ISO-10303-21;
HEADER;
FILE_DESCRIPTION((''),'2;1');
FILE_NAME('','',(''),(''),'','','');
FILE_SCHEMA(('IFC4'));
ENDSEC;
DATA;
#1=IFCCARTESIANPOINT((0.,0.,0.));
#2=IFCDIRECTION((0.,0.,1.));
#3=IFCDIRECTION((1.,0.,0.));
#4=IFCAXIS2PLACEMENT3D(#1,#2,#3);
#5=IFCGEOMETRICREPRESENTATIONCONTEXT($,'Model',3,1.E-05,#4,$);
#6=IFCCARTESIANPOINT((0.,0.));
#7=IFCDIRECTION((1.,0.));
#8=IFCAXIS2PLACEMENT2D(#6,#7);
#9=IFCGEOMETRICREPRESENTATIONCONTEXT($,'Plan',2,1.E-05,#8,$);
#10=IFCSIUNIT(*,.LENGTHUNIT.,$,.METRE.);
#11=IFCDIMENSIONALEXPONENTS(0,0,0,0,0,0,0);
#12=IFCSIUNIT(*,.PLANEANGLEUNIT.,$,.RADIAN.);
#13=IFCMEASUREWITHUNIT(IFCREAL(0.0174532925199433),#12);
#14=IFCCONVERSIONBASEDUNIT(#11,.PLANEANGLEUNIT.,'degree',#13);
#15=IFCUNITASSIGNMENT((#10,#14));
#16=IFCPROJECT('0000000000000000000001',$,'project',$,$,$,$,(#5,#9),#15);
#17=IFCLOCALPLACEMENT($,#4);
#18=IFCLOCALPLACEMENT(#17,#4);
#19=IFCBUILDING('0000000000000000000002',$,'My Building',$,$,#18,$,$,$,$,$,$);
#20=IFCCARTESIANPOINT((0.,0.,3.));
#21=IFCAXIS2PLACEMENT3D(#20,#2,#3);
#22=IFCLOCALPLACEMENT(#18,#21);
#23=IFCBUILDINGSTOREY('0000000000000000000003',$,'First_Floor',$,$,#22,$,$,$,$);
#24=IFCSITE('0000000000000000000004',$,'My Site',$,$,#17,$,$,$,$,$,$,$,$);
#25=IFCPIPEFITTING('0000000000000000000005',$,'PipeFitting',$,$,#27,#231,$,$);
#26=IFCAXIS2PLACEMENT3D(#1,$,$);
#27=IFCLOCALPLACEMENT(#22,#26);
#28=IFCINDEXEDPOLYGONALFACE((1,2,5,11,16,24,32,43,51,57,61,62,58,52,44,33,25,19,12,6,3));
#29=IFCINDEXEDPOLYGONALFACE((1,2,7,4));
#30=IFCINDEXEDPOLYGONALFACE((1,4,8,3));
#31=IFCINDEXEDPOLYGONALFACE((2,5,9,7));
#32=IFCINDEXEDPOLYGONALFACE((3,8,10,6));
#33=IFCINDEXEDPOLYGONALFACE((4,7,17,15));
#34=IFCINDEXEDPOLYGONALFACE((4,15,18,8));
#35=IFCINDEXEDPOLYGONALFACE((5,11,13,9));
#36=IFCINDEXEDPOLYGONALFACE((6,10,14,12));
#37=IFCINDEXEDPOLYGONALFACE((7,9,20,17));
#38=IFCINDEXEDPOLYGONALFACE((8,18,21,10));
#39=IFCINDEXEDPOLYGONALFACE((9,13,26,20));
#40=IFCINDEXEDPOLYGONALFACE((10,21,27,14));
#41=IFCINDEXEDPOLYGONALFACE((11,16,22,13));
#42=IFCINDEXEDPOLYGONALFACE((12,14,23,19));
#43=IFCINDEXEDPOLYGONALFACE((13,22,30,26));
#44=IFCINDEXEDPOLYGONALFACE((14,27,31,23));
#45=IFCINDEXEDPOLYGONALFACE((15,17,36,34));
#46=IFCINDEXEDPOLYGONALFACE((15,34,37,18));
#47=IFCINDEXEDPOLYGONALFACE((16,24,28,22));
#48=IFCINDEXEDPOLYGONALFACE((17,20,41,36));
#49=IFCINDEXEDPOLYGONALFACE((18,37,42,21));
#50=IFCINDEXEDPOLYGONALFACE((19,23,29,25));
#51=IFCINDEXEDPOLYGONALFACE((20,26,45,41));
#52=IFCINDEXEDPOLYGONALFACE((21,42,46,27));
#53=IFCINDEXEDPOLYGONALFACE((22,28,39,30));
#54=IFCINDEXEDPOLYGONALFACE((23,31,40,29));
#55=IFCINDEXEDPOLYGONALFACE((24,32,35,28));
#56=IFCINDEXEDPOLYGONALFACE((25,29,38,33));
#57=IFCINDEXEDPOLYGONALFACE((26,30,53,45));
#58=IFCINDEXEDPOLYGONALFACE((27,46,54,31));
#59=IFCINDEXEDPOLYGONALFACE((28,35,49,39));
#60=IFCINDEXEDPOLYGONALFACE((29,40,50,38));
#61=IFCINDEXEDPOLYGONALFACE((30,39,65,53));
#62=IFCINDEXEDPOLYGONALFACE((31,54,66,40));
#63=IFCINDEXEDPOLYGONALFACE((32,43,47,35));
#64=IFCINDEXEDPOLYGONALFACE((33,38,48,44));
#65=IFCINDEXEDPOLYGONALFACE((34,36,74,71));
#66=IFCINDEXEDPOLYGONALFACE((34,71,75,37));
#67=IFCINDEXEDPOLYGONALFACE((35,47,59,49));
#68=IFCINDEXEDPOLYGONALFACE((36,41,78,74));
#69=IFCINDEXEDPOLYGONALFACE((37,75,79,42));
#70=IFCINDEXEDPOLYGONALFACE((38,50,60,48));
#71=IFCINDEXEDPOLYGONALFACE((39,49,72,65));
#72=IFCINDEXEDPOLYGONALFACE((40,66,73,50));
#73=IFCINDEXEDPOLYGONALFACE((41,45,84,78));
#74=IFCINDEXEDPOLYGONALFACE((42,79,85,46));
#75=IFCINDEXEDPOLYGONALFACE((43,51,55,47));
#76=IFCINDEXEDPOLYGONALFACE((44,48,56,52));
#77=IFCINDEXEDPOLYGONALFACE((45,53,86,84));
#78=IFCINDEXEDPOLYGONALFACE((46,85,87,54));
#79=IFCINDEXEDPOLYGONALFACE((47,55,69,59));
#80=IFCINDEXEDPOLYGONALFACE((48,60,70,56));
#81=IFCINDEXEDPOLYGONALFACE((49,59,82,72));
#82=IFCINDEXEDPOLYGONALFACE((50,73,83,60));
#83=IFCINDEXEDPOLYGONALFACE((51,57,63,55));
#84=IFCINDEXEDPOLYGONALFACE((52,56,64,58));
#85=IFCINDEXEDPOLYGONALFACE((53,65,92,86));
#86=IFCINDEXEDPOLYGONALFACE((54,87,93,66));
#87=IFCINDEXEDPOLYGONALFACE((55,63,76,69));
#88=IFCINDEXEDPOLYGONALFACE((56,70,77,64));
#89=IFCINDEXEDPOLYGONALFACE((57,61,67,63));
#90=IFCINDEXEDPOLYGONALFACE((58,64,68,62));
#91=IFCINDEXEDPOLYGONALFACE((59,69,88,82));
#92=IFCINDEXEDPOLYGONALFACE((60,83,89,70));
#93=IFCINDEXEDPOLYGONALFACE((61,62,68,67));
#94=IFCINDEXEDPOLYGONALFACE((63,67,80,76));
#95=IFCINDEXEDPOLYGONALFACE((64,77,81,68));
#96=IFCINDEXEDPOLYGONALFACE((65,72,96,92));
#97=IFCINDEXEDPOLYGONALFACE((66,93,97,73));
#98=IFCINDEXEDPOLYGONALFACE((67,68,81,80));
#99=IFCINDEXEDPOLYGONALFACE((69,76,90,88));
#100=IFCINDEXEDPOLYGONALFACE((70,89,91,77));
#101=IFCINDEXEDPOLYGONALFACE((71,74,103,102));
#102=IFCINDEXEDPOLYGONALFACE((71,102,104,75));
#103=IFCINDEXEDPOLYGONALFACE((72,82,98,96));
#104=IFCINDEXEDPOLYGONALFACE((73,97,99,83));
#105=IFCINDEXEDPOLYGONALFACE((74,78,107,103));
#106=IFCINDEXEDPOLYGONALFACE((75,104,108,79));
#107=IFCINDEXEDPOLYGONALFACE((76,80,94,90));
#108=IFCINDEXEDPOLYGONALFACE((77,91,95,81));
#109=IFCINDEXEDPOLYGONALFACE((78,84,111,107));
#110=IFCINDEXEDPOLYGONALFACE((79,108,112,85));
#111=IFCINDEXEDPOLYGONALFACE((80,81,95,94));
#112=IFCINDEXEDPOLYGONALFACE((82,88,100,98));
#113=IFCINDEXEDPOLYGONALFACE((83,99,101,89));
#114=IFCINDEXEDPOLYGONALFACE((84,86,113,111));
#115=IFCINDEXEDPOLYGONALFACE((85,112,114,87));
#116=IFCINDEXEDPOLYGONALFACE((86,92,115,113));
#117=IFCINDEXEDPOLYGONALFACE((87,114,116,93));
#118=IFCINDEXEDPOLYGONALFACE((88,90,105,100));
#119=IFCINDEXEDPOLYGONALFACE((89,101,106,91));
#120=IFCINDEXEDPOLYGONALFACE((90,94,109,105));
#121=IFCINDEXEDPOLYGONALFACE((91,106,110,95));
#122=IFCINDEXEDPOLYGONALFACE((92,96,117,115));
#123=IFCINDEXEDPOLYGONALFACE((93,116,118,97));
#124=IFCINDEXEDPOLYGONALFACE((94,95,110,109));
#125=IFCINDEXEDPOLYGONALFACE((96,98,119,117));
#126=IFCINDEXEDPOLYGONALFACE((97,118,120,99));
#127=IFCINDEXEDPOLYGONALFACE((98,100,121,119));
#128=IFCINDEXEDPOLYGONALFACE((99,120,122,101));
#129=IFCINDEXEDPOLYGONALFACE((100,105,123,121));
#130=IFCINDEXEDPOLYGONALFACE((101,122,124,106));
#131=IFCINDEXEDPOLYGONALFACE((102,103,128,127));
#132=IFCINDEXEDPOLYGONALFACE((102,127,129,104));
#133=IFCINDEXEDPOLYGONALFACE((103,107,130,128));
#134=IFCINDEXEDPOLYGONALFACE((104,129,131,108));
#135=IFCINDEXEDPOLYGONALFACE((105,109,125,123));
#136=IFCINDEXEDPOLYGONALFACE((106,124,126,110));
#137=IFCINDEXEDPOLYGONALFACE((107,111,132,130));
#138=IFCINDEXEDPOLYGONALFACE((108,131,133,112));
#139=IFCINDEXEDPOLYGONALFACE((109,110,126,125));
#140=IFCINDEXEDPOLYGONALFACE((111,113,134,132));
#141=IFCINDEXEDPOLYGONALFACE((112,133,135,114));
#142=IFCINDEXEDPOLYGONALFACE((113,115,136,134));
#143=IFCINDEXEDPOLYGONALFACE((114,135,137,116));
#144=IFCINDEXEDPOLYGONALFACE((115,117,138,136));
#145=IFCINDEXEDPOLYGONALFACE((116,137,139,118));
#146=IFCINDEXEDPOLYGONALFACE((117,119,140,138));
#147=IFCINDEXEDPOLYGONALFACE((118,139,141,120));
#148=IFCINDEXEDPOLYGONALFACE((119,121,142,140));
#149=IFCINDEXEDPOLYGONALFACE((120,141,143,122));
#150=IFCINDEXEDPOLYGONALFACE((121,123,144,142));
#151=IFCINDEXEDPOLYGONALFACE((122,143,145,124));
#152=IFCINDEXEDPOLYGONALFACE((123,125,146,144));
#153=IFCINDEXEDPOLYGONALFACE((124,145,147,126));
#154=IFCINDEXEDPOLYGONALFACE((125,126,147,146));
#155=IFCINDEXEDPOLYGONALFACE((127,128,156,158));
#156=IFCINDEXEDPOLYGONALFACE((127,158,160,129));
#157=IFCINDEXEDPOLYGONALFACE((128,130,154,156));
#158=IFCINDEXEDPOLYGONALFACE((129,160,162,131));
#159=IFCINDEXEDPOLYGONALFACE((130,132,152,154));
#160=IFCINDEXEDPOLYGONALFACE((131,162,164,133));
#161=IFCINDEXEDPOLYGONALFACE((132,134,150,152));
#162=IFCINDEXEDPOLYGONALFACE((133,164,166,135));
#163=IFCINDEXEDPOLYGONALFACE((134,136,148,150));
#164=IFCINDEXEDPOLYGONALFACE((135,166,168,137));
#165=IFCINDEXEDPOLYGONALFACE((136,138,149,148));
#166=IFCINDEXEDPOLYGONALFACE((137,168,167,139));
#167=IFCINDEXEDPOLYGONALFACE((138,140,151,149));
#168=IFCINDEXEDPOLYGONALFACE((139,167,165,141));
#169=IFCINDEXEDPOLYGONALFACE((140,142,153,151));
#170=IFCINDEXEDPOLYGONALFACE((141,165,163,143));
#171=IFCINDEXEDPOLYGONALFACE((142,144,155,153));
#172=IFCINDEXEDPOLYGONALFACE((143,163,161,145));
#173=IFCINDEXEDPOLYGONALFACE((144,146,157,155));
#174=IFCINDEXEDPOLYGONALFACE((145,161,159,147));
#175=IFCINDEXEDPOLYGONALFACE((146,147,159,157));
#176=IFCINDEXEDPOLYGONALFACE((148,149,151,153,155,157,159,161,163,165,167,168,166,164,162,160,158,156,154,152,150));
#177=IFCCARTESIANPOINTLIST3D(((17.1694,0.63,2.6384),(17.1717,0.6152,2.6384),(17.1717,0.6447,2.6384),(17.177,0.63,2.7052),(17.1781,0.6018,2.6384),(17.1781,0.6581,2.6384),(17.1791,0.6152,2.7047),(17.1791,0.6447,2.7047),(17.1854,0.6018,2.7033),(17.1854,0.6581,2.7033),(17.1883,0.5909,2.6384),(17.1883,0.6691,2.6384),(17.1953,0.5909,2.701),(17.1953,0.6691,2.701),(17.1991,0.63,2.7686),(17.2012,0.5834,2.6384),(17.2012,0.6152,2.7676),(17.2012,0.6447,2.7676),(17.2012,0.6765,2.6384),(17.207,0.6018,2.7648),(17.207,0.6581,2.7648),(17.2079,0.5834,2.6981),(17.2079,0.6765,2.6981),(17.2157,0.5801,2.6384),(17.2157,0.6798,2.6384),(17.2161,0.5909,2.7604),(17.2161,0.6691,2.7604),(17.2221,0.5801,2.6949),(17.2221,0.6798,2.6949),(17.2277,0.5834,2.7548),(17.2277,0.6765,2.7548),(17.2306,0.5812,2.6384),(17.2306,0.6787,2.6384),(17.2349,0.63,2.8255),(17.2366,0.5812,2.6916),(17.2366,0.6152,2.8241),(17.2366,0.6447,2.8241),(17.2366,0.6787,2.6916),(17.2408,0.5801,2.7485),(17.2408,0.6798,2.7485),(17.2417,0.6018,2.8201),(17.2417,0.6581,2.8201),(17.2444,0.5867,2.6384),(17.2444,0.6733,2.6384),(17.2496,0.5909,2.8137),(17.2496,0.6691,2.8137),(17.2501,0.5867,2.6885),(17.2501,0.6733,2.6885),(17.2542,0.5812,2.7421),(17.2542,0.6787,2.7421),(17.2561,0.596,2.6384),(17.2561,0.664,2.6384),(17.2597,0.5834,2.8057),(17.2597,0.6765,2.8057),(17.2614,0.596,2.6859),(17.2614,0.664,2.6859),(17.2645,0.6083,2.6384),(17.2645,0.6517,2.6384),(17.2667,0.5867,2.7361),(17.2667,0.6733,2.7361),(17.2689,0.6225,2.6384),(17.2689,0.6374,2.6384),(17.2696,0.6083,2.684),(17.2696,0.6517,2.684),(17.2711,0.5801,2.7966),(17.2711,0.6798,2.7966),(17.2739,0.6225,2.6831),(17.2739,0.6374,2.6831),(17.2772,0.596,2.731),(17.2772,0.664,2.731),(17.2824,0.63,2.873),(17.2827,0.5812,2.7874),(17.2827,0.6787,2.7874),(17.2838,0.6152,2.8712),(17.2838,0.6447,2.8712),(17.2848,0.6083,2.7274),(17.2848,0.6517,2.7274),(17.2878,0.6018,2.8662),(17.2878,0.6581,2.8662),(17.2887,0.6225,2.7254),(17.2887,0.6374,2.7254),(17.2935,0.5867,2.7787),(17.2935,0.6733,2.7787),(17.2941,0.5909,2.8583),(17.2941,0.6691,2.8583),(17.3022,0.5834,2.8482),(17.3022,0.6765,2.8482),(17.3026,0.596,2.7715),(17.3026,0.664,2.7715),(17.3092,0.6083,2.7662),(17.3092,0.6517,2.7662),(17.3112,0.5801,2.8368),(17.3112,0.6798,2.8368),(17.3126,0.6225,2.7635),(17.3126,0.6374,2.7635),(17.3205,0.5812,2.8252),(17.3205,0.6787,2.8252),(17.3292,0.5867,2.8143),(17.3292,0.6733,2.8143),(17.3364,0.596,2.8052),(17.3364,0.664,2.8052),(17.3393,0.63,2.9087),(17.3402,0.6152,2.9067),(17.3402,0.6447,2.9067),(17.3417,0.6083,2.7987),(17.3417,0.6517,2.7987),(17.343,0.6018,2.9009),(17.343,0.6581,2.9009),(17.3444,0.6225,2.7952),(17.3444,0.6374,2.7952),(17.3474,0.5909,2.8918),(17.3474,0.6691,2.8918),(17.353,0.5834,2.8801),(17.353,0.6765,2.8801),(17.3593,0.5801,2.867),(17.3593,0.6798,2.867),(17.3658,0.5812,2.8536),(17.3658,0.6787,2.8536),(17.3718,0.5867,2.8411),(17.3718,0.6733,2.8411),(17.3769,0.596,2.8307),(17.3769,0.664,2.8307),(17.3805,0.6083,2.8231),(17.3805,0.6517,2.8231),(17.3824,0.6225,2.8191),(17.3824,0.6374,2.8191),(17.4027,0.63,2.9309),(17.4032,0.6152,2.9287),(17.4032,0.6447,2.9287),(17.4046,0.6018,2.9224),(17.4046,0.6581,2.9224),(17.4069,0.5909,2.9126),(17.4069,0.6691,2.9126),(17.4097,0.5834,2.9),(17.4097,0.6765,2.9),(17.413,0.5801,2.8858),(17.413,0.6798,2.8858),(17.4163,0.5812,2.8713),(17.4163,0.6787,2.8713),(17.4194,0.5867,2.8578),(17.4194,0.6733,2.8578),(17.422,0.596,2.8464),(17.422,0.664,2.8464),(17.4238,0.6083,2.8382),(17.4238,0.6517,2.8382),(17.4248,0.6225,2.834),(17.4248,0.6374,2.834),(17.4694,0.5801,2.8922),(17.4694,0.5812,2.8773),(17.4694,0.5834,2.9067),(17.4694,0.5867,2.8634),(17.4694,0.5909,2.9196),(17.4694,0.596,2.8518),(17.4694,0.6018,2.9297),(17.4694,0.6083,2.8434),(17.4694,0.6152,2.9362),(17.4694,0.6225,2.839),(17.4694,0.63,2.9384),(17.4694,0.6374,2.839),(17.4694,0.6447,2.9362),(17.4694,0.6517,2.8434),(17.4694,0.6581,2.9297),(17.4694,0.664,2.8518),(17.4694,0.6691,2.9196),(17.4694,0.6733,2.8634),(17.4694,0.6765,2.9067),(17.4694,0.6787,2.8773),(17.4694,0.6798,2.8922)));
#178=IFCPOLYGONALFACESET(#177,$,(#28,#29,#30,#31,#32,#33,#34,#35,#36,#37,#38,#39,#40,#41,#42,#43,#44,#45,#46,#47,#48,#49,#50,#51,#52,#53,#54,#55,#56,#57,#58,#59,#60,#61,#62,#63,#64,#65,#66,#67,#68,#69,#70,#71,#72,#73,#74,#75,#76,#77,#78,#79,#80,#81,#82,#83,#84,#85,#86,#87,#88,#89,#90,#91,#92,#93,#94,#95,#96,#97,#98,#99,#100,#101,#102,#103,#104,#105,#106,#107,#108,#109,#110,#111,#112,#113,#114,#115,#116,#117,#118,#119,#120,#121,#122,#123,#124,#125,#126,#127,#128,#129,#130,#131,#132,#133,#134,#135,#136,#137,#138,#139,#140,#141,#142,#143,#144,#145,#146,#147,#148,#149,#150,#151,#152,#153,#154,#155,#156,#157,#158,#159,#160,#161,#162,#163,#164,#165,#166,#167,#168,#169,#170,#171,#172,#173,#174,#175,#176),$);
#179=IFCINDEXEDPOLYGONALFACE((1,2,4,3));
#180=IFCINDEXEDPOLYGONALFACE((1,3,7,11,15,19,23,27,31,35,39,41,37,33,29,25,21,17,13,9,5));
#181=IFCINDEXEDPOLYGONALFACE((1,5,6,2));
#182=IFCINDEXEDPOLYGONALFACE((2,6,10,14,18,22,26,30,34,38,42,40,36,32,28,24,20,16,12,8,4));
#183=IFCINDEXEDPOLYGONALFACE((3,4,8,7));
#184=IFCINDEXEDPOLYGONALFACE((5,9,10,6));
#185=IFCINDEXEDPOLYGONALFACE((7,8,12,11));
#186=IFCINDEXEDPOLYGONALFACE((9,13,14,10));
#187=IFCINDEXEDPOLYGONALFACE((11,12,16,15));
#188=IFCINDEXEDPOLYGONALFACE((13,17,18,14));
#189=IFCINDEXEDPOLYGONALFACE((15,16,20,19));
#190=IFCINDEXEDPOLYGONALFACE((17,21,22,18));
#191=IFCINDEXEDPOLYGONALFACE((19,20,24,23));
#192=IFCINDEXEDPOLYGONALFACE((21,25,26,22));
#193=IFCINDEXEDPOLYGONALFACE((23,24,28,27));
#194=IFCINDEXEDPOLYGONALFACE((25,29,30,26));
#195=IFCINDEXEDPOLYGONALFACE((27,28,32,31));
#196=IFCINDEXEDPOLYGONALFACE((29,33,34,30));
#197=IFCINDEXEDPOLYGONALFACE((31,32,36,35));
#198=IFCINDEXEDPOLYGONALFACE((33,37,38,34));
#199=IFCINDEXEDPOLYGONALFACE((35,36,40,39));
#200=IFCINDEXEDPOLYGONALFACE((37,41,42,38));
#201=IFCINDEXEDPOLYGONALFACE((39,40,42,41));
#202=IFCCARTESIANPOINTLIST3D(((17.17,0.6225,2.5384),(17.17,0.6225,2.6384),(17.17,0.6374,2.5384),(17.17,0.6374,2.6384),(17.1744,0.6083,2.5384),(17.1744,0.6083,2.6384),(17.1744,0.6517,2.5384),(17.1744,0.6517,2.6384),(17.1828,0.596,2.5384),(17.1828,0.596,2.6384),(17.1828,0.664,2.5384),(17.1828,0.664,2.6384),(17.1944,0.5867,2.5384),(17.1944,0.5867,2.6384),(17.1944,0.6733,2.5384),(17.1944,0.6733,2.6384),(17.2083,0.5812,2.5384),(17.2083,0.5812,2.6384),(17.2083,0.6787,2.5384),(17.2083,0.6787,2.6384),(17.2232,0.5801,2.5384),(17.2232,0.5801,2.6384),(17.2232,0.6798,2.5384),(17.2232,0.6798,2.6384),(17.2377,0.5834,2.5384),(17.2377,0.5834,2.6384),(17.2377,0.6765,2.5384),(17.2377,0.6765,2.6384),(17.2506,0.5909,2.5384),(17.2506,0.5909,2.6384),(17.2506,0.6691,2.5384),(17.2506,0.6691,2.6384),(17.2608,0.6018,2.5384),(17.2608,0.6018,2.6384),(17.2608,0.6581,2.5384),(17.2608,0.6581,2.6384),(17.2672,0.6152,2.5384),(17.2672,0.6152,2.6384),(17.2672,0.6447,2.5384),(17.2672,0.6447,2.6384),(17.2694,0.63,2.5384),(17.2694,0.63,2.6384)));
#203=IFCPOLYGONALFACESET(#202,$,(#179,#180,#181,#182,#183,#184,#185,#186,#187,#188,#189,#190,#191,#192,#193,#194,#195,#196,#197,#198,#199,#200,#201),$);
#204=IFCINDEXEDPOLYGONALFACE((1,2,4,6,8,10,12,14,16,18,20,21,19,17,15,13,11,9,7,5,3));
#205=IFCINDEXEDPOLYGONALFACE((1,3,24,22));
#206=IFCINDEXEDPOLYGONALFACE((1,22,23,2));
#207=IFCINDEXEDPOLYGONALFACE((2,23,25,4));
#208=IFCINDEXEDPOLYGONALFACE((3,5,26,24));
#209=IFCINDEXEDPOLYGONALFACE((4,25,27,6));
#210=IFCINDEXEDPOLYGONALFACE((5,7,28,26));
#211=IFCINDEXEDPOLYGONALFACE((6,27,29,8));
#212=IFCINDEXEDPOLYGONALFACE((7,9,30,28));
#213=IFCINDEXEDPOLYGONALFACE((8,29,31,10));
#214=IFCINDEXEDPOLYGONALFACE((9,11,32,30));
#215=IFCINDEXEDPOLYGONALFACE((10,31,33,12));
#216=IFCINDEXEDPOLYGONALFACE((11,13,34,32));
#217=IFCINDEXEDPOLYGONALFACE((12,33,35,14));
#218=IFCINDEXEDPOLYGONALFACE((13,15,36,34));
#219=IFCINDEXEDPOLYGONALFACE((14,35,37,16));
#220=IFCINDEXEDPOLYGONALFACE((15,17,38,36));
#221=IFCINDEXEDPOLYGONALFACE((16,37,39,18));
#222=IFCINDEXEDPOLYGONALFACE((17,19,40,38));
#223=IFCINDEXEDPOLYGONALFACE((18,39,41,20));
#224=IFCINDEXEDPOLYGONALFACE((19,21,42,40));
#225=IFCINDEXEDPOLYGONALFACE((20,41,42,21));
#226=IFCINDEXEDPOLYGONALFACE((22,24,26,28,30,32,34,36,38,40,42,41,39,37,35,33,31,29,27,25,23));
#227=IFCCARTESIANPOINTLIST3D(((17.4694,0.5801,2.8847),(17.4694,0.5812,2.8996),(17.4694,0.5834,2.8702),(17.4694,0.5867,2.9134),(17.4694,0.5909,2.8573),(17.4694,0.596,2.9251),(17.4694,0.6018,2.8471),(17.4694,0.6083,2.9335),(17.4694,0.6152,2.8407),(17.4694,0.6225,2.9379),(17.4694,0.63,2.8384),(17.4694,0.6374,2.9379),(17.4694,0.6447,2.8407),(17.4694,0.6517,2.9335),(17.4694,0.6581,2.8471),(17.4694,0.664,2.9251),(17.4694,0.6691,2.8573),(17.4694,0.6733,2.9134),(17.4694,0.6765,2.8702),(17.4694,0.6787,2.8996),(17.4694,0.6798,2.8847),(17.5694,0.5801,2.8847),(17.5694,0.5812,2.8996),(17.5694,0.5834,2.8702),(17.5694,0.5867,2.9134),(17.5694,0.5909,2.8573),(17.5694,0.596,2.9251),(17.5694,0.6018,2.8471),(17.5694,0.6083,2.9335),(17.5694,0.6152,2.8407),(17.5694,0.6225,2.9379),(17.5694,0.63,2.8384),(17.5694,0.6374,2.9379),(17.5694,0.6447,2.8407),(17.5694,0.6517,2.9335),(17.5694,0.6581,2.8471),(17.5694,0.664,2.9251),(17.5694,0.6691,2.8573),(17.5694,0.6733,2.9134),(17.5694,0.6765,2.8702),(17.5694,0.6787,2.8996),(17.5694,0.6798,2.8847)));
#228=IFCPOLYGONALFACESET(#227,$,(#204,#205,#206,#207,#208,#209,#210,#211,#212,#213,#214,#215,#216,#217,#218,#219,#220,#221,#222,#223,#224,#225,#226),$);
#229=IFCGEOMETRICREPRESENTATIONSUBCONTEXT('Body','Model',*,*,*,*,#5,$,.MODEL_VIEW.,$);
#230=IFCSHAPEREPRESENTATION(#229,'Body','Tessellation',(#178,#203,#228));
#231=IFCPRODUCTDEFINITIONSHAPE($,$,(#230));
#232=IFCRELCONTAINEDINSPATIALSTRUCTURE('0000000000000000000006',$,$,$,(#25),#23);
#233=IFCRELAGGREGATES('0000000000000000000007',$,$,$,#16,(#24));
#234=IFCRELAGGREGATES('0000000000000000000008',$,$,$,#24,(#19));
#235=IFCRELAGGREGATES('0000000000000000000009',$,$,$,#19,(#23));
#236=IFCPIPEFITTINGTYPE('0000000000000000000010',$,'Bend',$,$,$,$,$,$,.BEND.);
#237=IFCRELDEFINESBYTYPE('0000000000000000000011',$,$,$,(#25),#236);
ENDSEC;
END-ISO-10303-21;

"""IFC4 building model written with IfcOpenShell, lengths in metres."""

from ifc_helpers import new_model, entity, si_unit, converted_unit, frame, origin_with_axes, origin_2d_with_axis, place, context, subcontext, project, spatial, circle, extrude, source, transform, mapped, type_object, type_shapes, element, save


model = new_model("IFC4")

# Units and contexts
model_context = context("Model", 3, precision=1e-05, world=origin_with_axes())
plan_context = context("Plan", 2, precision=1e-05, world=origin_2d_with_axis())
body_context = subcontext(model_context, "Body", "Model", "MODEL_VIEW")
ifc_project = project(units=[si_unit("LENGTHUNIT", "METRE"), converted_unit("PLANEANGLEUNIT", "degree", entity("IfcReal", 0.0174532925199433), si_unit("PLANEANGLEUNIT", "RADIAN"), dimensions=[0, 0, 0, 0, 0, 0, 0])], contexts=[model_context, plan_context])

# Site, building, storey
site_placement = place(None, origin_with_axes())
site = spatial("IfcSite", under=ifc_project, at=site_placement, Name="My Site")
building_placement = place(site_placement, origin_with_axes())
building = spatial("IfcBuilding", under=site, at=building_placement, Name="My Building")
storey_placement = place(building_placement, frame((0.0, 0.0, 3.0), z_axis=(0.0, 0.0, 1.0), x_axis=(1.0, 0.0, 0.0)))
storey = spatial("IfcBuildingStorey", under=building, at=storey_placement, Name="First_Floor")

# Pipe fitting
pipe_fitting_type = type_object("IfcPipeFittingType", Name="Bend", PredefinedType="BEND")
shared_shape = source(origin_with_axes(), body_context, "Body", "SolidModel", [
    entity("IfcSweptDiskSolid", entity("IfcIndexedPolyCurve", entity("IfcCartesianPointList3D", [[0.0, 0.0, -0.1], [0.0732, 0.0, -0.2768], [0.25, 0.0, -0.35]]), [entity("IfcArcIndex", [1, 2, 3])]), 0.05),
    extrude(circle(Radius=0.05), origin_with_axes(), (0.0, 0.0, -1.0), 0.1),
    extrude(circle(Radius=0.05), frame((0.25, 0.0, -0.35), z_axis=(1.0, 0.0, 0.0), x_axis=(0.0, 0.0, 1.0)), (0.0, 0.0, 1.0), 0.1),
])
type_shapes(pipe_fitting_type, [shared_shape])
for number, where, z_axis, x_axis, name in (
    (1, (17.2194, 0.63, 2.5384), (0.0, 0.0, -1.0), (1.0, 0.000001, 0.0), "PipeFitting"),
):
    element("IfcPipeFitting", number, at=place(storey_placement, frame(where, z_axis=z_axis, x_axis=x_axis)), inside=storey, type_object=pipe_fitting_type, Name=name, context=body_context, shape_type="MappedRepresentation", body=[
        mapped(shared_shape, transform((0.0, 0.0, 0.0), x_axis=(1.0, 0.0, 0.0), y_axis=(0.0, 1.0, 0.0), z_axis=(0.0, 0.0, 1.0), scale=1.0)),
    ])

save(model, "model.ifc")
